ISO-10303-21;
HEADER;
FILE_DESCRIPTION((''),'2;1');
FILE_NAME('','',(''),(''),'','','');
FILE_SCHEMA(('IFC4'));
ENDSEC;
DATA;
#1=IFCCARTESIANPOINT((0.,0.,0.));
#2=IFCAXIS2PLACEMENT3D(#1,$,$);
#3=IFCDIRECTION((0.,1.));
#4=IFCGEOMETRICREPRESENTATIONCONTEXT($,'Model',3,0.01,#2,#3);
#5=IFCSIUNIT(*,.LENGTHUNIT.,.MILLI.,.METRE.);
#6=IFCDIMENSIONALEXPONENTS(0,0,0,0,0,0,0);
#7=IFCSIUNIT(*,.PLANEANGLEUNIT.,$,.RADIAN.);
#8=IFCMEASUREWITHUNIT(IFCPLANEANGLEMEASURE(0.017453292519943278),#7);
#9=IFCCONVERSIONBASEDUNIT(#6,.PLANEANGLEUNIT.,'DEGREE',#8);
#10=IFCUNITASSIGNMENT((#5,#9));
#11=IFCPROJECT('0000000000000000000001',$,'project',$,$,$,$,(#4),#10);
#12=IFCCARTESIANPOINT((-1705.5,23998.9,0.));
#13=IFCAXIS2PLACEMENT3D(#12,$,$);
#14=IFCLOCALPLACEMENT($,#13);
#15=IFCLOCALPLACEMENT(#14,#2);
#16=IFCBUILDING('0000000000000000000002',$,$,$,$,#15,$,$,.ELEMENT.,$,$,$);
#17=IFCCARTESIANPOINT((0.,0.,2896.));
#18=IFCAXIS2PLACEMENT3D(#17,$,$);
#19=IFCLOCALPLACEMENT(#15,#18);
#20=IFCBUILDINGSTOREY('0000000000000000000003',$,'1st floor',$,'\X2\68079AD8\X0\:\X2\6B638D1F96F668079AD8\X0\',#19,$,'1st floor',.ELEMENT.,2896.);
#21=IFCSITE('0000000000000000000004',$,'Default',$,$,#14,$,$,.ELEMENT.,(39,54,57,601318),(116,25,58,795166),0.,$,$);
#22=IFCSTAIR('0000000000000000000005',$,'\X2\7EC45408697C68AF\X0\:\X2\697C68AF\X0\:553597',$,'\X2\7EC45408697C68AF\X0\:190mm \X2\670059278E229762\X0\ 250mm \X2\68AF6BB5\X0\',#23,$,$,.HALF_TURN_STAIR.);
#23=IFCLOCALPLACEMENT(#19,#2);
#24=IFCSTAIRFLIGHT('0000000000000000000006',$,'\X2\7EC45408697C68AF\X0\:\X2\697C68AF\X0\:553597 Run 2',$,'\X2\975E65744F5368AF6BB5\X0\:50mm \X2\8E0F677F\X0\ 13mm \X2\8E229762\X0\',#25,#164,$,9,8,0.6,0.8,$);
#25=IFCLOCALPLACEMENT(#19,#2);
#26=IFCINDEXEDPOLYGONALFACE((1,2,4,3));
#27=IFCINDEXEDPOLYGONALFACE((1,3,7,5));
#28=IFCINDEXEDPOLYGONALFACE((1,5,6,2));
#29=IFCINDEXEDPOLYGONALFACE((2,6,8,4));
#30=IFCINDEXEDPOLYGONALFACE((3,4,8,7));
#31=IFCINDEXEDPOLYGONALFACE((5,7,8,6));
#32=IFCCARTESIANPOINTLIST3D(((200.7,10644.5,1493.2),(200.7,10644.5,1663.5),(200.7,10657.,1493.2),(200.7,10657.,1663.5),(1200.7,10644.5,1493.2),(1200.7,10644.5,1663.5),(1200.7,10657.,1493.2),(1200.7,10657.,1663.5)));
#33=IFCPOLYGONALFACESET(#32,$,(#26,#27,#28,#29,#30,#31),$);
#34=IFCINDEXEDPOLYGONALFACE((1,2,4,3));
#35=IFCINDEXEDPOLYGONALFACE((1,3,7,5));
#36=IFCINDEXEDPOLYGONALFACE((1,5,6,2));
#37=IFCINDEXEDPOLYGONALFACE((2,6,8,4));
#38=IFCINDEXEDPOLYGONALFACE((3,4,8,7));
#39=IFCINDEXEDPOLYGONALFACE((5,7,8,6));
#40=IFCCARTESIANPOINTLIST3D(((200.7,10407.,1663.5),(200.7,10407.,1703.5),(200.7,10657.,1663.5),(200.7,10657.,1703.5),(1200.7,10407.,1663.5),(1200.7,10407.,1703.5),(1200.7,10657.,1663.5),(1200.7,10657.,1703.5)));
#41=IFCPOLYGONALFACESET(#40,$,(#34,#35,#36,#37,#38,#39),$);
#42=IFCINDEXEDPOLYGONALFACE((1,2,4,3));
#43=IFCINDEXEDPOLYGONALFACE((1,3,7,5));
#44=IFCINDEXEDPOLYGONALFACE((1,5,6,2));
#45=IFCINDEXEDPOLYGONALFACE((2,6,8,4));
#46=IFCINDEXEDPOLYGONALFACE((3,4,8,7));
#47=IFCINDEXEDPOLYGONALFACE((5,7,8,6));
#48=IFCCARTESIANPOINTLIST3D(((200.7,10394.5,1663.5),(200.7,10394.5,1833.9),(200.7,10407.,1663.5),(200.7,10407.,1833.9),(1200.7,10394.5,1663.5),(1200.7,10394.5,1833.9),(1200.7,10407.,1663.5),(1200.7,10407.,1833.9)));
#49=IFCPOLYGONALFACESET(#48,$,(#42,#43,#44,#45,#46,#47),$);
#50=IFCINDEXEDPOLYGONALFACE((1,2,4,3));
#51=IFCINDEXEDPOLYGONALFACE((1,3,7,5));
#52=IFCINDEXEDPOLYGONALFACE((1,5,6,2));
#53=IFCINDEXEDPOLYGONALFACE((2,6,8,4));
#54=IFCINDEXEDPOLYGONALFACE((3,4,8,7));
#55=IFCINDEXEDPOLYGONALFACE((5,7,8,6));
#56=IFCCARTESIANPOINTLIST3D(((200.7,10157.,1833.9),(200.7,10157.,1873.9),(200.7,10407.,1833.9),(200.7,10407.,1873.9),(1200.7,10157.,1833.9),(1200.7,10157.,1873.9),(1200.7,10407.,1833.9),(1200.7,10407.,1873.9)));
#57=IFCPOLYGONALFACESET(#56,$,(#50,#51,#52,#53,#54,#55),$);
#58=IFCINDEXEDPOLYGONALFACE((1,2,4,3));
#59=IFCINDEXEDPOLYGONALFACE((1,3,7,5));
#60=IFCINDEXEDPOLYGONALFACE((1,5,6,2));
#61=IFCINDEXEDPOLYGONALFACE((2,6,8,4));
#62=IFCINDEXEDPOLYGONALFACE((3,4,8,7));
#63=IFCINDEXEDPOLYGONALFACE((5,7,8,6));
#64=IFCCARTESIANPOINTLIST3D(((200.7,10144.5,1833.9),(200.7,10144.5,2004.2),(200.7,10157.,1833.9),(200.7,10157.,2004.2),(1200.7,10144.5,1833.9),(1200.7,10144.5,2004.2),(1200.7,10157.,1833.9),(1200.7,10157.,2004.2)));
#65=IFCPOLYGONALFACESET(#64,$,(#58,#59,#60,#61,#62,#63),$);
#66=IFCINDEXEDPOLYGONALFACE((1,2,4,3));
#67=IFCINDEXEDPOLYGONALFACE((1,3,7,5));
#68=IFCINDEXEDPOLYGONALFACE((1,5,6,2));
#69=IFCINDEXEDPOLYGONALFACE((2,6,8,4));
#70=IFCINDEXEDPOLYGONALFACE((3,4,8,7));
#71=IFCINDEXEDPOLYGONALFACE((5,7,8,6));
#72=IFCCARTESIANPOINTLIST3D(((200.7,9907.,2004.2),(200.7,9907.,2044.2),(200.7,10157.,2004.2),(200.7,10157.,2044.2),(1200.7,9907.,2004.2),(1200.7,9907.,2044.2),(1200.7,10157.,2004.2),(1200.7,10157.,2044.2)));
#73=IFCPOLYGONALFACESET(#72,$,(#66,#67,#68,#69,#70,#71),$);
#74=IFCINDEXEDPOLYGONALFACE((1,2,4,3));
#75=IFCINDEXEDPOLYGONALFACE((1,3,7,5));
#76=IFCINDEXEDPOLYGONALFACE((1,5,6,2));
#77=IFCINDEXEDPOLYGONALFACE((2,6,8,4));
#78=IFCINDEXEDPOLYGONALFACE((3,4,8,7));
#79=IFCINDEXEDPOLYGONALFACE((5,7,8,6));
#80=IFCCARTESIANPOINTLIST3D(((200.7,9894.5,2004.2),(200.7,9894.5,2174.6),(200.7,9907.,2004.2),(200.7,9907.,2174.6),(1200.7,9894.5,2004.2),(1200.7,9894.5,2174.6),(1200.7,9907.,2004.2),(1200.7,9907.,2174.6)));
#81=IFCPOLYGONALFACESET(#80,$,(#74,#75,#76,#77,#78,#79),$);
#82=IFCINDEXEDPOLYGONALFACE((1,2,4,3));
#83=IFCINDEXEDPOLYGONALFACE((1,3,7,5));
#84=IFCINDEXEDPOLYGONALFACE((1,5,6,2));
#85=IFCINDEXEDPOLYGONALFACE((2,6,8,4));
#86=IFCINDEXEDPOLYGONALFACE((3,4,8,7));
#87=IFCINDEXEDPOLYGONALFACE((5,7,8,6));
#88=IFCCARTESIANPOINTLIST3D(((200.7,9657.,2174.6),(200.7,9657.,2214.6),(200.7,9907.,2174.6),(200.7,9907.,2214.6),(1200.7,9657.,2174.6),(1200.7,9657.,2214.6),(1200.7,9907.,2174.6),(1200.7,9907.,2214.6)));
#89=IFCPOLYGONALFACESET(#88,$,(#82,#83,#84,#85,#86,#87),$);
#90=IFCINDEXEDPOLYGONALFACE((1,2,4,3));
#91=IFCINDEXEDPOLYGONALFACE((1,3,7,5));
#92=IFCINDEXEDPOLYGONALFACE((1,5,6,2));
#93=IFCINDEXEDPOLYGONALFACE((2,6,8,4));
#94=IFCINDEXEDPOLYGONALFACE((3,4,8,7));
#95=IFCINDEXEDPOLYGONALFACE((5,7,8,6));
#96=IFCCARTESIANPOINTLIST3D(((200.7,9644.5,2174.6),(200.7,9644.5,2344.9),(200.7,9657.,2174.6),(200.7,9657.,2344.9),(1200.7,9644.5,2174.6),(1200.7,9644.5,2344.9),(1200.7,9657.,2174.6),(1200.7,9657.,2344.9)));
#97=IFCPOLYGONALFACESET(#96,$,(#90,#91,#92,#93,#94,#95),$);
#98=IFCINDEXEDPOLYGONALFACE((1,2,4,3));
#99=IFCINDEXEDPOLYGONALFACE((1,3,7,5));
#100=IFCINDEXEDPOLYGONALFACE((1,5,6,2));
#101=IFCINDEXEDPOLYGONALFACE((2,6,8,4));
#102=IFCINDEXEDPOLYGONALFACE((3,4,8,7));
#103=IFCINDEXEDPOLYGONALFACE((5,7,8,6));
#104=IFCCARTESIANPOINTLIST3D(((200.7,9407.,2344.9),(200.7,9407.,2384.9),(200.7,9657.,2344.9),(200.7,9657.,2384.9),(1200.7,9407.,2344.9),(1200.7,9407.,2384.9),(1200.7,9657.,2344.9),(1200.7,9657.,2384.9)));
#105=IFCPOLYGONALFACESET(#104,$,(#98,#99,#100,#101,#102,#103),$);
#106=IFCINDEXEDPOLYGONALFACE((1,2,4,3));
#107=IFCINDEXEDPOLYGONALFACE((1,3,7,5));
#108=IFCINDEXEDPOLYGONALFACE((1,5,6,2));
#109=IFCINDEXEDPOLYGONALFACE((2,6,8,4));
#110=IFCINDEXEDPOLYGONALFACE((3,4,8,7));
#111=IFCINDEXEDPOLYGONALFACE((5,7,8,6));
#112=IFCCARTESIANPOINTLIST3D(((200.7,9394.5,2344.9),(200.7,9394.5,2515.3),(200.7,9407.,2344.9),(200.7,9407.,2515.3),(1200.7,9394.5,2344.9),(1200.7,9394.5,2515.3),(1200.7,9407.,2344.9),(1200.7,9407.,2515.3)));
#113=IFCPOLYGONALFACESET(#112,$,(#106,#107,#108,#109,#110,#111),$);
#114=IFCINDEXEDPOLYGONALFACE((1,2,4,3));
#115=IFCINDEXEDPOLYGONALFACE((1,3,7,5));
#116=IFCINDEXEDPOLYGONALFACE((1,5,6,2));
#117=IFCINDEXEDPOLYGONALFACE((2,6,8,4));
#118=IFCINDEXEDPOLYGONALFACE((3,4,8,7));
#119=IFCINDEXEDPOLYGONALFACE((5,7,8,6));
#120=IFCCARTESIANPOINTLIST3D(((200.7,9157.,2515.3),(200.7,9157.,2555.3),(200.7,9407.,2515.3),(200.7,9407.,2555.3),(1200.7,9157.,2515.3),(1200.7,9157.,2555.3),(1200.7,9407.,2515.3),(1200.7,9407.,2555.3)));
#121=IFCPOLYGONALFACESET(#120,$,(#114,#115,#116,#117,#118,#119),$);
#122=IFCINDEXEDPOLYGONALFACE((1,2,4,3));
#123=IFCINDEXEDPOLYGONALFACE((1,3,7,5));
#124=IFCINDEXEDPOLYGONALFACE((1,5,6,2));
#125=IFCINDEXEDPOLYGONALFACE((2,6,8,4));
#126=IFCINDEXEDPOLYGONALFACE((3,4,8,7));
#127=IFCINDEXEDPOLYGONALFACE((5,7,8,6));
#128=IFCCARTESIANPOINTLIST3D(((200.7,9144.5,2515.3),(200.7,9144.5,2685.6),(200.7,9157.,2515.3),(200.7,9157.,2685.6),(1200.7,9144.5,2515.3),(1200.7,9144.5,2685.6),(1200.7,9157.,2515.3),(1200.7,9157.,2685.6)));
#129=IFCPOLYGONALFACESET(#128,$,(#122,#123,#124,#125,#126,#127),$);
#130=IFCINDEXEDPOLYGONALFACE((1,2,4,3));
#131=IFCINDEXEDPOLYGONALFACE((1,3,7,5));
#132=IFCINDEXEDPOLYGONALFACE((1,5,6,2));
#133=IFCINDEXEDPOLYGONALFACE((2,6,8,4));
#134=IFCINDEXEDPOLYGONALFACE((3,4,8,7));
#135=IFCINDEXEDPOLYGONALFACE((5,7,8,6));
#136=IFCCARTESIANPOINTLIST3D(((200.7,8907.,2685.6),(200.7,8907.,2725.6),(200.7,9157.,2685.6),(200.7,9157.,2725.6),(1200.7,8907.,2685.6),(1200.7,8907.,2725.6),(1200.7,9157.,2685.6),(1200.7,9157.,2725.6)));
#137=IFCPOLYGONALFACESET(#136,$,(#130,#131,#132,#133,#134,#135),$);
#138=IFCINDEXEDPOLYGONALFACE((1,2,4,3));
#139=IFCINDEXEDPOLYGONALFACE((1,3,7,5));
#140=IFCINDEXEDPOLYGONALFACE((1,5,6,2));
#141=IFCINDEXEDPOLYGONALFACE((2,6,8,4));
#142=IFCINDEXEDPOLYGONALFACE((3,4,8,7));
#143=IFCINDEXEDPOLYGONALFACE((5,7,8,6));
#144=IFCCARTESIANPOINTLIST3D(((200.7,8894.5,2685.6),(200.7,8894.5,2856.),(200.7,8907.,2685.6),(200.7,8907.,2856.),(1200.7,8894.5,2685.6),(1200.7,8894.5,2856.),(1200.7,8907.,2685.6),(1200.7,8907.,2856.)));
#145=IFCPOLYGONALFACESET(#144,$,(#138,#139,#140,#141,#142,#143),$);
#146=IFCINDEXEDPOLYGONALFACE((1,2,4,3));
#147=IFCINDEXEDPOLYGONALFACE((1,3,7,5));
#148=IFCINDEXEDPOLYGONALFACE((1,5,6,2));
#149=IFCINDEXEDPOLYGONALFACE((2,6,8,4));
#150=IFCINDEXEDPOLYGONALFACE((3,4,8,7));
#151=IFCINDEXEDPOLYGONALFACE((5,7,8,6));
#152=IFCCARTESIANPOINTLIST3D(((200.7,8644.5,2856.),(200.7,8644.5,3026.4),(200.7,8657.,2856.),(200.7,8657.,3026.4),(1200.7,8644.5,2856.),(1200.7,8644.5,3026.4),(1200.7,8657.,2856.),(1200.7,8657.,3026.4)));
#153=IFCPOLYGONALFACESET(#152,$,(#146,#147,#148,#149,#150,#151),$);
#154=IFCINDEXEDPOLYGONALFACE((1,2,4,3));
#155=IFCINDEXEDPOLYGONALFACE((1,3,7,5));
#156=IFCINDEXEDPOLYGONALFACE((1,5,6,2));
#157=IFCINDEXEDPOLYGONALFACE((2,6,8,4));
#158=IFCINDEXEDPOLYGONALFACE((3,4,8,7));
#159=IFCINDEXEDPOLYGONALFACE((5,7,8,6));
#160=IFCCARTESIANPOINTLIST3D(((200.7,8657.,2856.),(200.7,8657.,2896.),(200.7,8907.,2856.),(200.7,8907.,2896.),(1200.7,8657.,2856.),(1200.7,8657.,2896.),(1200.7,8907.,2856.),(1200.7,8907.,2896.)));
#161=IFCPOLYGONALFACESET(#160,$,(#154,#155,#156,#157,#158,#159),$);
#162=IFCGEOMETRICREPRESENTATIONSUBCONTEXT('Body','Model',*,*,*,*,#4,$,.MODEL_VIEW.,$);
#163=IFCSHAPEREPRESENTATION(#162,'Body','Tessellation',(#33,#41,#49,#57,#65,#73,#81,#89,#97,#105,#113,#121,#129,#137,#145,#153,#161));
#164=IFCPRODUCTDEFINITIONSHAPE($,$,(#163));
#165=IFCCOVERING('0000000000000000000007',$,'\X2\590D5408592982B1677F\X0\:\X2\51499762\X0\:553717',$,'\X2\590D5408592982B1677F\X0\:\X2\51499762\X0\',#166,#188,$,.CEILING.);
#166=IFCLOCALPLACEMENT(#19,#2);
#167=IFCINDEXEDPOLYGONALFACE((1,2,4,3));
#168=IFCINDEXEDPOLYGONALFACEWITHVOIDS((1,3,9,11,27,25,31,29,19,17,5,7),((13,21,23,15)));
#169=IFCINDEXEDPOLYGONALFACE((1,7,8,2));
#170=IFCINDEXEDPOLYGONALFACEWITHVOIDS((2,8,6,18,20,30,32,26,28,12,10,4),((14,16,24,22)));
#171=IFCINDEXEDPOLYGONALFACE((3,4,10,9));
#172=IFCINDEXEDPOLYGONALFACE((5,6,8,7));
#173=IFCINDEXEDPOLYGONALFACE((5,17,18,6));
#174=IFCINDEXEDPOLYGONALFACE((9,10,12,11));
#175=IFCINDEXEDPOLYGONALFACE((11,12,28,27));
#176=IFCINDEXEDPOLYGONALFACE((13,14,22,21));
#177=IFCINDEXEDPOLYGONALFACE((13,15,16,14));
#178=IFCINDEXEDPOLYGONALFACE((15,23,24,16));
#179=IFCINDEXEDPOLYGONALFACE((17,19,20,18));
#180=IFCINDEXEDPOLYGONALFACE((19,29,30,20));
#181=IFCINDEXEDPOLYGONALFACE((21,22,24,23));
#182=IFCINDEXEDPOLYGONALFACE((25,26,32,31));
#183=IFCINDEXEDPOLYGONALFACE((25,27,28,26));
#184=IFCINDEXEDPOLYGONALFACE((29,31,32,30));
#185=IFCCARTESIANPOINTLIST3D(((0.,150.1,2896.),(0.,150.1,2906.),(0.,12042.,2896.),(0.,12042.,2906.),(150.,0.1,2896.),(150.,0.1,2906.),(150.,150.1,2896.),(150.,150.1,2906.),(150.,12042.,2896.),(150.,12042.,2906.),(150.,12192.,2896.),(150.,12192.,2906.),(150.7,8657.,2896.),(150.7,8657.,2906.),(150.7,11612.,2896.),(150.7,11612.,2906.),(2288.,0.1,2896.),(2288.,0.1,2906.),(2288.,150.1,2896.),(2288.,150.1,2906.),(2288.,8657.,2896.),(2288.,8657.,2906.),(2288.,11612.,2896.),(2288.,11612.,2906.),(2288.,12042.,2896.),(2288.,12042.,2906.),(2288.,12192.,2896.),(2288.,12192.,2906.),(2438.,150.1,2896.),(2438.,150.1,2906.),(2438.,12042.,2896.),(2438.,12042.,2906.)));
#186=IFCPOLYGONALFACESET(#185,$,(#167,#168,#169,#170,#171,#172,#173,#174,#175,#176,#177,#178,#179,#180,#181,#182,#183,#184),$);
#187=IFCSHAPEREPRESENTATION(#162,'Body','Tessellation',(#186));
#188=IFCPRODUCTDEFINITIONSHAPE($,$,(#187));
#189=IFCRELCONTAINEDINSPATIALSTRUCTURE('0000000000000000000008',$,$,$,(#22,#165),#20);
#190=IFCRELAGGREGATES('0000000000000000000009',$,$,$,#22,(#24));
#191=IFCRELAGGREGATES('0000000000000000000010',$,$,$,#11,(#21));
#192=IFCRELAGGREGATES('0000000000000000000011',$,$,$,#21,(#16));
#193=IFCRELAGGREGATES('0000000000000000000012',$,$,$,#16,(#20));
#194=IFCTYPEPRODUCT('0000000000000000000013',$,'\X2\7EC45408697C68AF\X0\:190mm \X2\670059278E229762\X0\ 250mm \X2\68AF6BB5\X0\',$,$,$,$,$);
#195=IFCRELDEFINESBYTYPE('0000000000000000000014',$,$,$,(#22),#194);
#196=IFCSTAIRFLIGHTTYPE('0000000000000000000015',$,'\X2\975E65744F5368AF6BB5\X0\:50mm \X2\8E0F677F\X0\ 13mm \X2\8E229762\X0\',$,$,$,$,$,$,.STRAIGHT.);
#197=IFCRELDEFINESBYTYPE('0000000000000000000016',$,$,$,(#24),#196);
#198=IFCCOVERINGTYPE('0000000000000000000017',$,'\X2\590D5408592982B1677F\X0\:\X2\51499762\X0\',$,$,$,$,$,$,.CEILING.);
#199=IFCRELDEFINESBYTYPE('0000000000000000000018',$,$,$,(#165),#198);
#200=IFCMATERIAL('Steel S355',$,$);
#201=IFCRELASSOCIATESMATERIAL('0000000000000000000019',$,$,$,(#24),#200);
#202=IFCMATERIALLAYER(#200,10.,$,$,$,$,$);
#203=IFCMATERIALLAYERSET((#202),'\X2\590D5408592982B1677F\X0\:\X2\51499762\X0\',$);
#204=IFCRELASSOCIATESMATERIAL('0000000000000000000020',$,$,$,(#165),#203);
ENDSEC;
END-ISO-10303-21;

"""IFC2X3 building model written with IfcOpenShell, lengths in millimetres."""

from ifc_helpers import new_model, entity, si_unit, converted_unit, direction, frame, frame_2d, origin, origin_2d_with_axis, place, context, subcontext, project, spatial, polyline, rectangle, outline, extrude, material, layer, layer_set, layer_usage, type_object, element, aggregate, save


model = new_model("IFC2X3")

# Units and contexts
model_context = context("Model", 3, precision=0.01, world=origin(), true_north=direction((0.0, 1.0)))
body_context = subcontext(model_context, "Body", "Model", "MODEL_VIEW")
ifc_project = project(units=[si_unit("LENGTHUNIT", "METRE", prefix="MILLI"), converted_unit("PLANEANGLEUNIT", "DEGREE", entity("IfcPlaneAngleMeasure", 0.017453292519943278), si_unit("PLANEANGLEUNIT", "RADIAN"), dimensions=[0, 0, 0, 0, 0, 0, 0])], contexts=[model_context])

# Site, building, storey
site_placement = place(None, frame((-1705.5, 23998.9, 0.0)))
site = spatial("IfcSite", under=ifc_project, at=site_placement, Name="Default", CompositionType="ELEMENT", RefLatitude=(39, 54, 57, 601318), RefLongitude=(116, 25, 58, 795166), RefElevation=0.0)
building_placement = place(site_placement, origin())
building = spatial("IfcBuilding", under=site, at=building_placement, CompositionType="ELEMENT")
storey_placement = place(building_placement, frame((0.0, 0.0, 2896.0)))
storey = spatial("IfcBuildingStorey", under=building, at=storey_placement, Name="1st floor", ObjectType="标高:正负零标高", LongName="1st floor", CompositionType="ELEMENT", Elevation=2896.0)

# Stair
type_product = type_object("IfcTypeProduct", Name="组合楼梯:190mm 最大踢面 250mm 梯段")
stair_placement = place(storey_placement, origin())
stair = element("IfcStair", 1, at=stair_placement, inside=storey, type_object=type_product, Name="组合楼梯:楼梯:553597", ObjectType="组合楼梯:190mm 最大踢面 250mm 梯段", ShapeType="HALF_TURN_STAIR")
ifc_material_1 = material(Name="Steel S355")

# Stair flight
stair_flight_type = type_object("IfcStairFlightType", Name="非整体梯段:50mm 踏板 13mm 踢面", PredefinedType="STRAIGHT")
stair_flight_1_placement = place(stair_placement, origin())
stair_flight_1 = element("IfcStairFlight", 2, at=stair_flight_1_placement, type_object=stair_flight_type, material=ifc_material_1, Name="组合楼梯:楼梯:553597 Run 2", ObjectType="非整体梯段:50mm 踏板 13mm 踢面", NumberOfRiser=9, NumberOfTreads=8, RiserHeight=0.6, TreadLength=0.8, context=body_context, shape_type="SweptSolid", body=[
    extrude(rectangle(XDim=1000.0, YDim=12.5, at=frame_2d((0.0, 0.0), x_axis=(1.0, 0.0))), frame((700.7, 10650.7, 1493.2)), (0.0, 0.0, 1.0), 170.4),
    extrude(rectangle(XDim=250.0, YDim=1000.0, at=frame_2d((0.0, 0.0), x_axis=(1.0, 0.0))), frame((700.7, 10532.0, 1663.5), z_axis=(0.0, 0.0, 1.0), x_axis=(0.0, 1.0, 0.0)), (0.0, 0.0, 1.0), 40.0),
    extrude(rectangle(XDim=1000.0, YDim=12.5, at=frame_2d((0.0, 0.0), x_axis=(1.0, 0.0))), frame((700.7, 10400.7, 1663.5)), (0.0, 0.0, 1.0), 170.4),
    extrude(rectangle(XDim=250.0, YDim=1000.0, at=origin_2d_with_axis()), frame((700.7, 10282.0, 1833.9), z_axis=(0.0, 0.0, 1.0), x_axis=(0.0, 1.0, 0.0)), (0.0, 0.0, 1.0), 40.0),
    extrude(rectangle(XDim=1000.0, YDim=12.5, at=frame_2d((0.0, 0.0), x_axis=(1.0, 0.0))), frame((700.7, 10150.7, 1833.9)), (0.0, 0.0, 1.0), 170.4),
    extrude(rectangle(XDim=250.0, YDim=1000.0, at=frame_2d((0.0, 0.0), x_axis=(1.0, 0.0))), frame((700.7, 10032.0, 2004.2), z_axis=(0.0, 0.0, 1.0), x_axis=(0.0, 1.0, 0.0)), (0.0, 0.0, 1.0), 40.0),
    extrude(rectangle(XDim=1000.0, YDim=12.5, at=frame_2d((0.0, 0.0), x_axis=(1.0, 0.0))), frame((700.7, 9900.7, 2004.2)), (0.0, 0.0, 1.0), 170.4),
    extrude(rectangle(XDim=250.0, YDim=1000.0, at=origin_2d_with_axis()), frame((700.7, 9782.0, 2174.6), z_axis=(0.0, 0.0, 1.0), x_axis=(0.0, 1.0, 0.0)), (0.0, 0.0, 1.0), 40.0),
    extrude(rectangle(XDim=1000.0, YDim=12.5, at=frame_2d((0.0, 0.0), x_axis=(1.0, 0.0))), frame((700.7, 9650.7, 2174.6)), (0.0, 0.0, 1.0), 170.4),
    extrude(rectangle(XDim=250.0, YDim=1000.0, at=frame_2d((0.0, 0.0), x_axis=(1.0, 0.0))), frame((700.7, 9532.0, 2344.9), z_axis=(0.0, 0.0, 1.0), x_axis=(0.0, 1.0, 0.0)), (0.0, 0.0, 1.0), 40.0),
    extrude(rectangle(XDim=1000.0, YDim=12.5, at=frame_2d((0.0, 0.0), x_axis=(1.0, 0.0))), frame((700.7, 9400.7, 2344.9)), (0.0, 0.0, 1.0), 170.4),
    extrude(rectangle(XDim=250.0, YDim=1000.0, at=origin_2d_with_axis()), frame((700.7, 9282.0, 2515.3), z_axis=(0.0, 0.0, 1.0), x_axis=(0.0, 1.0, 0.0)), (0.0, 0.0, 1.0), 40.0),
    extrude(rectangle(XDim=1000.0, YDim=12.5, at=frame_2d((0.0, 0.0), x_axis=(1.0, 0.0))), frame((700.7, 9150.7, 2515.3)), (0.0, 0.0, 1.0), 170.4),
    extrude(rectangle(XDim=250.0, YDim=1000.0, at=frame_2d((0.0, 0.0), x_axis=(1.0, 0.0))), frame((700.7, 9032.0, 2685.6), z_axis=(0.0, 0.0, 1.0), x_axis=(0.0, 1.0, 0.0)), (0.0, 0.0, 1.0), 40.0),
    extrude(rectangle(XDim=1000.0, YDim=12.5, at=frame_2d((0.0, 0.0), x_axis=(1.0, 0.0))), frame((700.7, 8900.7, 2685.6)), (0.0, 0.0, 1.0), 170.4),
    extrude(rectangle(XDim=1000.0, YDim=12.5, at=frame_2d((0.0, 0.0), x_axis=(1.0, 0.0))), frame((700.7, 8650.7, 2856.0)), (0.0, 0.0, 1.0), 170.4),
    extrude(rectangle(XDim=250.0, YDim=1000.0, at=origin_2d_with_axis()), frame((700.7, 8782.0, 2856.0), z_axis=(0.0, 0.0, 1.0), x_axis=(0.0, 1.0, 0.0)), (0.0, 0.0, 1.0), 40.0),
])
aggregate(stair, [stair_flight_1])

# Covering
ifc_layer_1 = layer(ifc_material_1, 10.0)
ifc_layer_set_1 = layer_set([ifc_layer_1], Name="复合天花板:光面")
ifc_layer_usage_1 = layer_usage(ifc_layer_set_1, "AXIS3", "NEGATIVE", 10.0)
covering_type = type_object("IfcCoveringType", Name="复合天花板:光面", PredefinedType="CEILING")
covering_placement = place(storey_placement, origin())
element("IfcCovering", 3, at=covering_placement, inside=storey, type_object=covering_type, material=ifc_layer_usage_1, Name="复合天花板:光面:553717", ObjectType="复合天花板:光面", PredefinedType="CEILING", context=body_context, shape_type="SweptSolid", body=[
    extrude(outline(polyline([(5946.0, -1069.0), (6096.0, -1069.0), (6096.0, 1069.0), (5945.9, 1069.0), (5945.9, 1219.0), (-5946.0, 1219.0), (-5946.0, 1069.0), (-6096.0, 1069.0), (-6096.0, -1069.0), (-5946.0, -1069.0), (-5946.0, -1219.0), (5946.0, -1219.0), (5946.0, -1069.0)]), holes=[polyline([(5516.0, 1068.3), (5516.0, -1069.0), (2561.0, -1069.0), (2561.0, 1068.3), (5516.0, 1068.3)])]), frame((1219.0, 6096.0, 2896.0), z_axis=(0.0, 0.0, 1.0), x_axis=(0.0, 1.0, 0.0)), (0.0, 0.0, 1.0), 10.0),
])

save(model, "model.ifc")
